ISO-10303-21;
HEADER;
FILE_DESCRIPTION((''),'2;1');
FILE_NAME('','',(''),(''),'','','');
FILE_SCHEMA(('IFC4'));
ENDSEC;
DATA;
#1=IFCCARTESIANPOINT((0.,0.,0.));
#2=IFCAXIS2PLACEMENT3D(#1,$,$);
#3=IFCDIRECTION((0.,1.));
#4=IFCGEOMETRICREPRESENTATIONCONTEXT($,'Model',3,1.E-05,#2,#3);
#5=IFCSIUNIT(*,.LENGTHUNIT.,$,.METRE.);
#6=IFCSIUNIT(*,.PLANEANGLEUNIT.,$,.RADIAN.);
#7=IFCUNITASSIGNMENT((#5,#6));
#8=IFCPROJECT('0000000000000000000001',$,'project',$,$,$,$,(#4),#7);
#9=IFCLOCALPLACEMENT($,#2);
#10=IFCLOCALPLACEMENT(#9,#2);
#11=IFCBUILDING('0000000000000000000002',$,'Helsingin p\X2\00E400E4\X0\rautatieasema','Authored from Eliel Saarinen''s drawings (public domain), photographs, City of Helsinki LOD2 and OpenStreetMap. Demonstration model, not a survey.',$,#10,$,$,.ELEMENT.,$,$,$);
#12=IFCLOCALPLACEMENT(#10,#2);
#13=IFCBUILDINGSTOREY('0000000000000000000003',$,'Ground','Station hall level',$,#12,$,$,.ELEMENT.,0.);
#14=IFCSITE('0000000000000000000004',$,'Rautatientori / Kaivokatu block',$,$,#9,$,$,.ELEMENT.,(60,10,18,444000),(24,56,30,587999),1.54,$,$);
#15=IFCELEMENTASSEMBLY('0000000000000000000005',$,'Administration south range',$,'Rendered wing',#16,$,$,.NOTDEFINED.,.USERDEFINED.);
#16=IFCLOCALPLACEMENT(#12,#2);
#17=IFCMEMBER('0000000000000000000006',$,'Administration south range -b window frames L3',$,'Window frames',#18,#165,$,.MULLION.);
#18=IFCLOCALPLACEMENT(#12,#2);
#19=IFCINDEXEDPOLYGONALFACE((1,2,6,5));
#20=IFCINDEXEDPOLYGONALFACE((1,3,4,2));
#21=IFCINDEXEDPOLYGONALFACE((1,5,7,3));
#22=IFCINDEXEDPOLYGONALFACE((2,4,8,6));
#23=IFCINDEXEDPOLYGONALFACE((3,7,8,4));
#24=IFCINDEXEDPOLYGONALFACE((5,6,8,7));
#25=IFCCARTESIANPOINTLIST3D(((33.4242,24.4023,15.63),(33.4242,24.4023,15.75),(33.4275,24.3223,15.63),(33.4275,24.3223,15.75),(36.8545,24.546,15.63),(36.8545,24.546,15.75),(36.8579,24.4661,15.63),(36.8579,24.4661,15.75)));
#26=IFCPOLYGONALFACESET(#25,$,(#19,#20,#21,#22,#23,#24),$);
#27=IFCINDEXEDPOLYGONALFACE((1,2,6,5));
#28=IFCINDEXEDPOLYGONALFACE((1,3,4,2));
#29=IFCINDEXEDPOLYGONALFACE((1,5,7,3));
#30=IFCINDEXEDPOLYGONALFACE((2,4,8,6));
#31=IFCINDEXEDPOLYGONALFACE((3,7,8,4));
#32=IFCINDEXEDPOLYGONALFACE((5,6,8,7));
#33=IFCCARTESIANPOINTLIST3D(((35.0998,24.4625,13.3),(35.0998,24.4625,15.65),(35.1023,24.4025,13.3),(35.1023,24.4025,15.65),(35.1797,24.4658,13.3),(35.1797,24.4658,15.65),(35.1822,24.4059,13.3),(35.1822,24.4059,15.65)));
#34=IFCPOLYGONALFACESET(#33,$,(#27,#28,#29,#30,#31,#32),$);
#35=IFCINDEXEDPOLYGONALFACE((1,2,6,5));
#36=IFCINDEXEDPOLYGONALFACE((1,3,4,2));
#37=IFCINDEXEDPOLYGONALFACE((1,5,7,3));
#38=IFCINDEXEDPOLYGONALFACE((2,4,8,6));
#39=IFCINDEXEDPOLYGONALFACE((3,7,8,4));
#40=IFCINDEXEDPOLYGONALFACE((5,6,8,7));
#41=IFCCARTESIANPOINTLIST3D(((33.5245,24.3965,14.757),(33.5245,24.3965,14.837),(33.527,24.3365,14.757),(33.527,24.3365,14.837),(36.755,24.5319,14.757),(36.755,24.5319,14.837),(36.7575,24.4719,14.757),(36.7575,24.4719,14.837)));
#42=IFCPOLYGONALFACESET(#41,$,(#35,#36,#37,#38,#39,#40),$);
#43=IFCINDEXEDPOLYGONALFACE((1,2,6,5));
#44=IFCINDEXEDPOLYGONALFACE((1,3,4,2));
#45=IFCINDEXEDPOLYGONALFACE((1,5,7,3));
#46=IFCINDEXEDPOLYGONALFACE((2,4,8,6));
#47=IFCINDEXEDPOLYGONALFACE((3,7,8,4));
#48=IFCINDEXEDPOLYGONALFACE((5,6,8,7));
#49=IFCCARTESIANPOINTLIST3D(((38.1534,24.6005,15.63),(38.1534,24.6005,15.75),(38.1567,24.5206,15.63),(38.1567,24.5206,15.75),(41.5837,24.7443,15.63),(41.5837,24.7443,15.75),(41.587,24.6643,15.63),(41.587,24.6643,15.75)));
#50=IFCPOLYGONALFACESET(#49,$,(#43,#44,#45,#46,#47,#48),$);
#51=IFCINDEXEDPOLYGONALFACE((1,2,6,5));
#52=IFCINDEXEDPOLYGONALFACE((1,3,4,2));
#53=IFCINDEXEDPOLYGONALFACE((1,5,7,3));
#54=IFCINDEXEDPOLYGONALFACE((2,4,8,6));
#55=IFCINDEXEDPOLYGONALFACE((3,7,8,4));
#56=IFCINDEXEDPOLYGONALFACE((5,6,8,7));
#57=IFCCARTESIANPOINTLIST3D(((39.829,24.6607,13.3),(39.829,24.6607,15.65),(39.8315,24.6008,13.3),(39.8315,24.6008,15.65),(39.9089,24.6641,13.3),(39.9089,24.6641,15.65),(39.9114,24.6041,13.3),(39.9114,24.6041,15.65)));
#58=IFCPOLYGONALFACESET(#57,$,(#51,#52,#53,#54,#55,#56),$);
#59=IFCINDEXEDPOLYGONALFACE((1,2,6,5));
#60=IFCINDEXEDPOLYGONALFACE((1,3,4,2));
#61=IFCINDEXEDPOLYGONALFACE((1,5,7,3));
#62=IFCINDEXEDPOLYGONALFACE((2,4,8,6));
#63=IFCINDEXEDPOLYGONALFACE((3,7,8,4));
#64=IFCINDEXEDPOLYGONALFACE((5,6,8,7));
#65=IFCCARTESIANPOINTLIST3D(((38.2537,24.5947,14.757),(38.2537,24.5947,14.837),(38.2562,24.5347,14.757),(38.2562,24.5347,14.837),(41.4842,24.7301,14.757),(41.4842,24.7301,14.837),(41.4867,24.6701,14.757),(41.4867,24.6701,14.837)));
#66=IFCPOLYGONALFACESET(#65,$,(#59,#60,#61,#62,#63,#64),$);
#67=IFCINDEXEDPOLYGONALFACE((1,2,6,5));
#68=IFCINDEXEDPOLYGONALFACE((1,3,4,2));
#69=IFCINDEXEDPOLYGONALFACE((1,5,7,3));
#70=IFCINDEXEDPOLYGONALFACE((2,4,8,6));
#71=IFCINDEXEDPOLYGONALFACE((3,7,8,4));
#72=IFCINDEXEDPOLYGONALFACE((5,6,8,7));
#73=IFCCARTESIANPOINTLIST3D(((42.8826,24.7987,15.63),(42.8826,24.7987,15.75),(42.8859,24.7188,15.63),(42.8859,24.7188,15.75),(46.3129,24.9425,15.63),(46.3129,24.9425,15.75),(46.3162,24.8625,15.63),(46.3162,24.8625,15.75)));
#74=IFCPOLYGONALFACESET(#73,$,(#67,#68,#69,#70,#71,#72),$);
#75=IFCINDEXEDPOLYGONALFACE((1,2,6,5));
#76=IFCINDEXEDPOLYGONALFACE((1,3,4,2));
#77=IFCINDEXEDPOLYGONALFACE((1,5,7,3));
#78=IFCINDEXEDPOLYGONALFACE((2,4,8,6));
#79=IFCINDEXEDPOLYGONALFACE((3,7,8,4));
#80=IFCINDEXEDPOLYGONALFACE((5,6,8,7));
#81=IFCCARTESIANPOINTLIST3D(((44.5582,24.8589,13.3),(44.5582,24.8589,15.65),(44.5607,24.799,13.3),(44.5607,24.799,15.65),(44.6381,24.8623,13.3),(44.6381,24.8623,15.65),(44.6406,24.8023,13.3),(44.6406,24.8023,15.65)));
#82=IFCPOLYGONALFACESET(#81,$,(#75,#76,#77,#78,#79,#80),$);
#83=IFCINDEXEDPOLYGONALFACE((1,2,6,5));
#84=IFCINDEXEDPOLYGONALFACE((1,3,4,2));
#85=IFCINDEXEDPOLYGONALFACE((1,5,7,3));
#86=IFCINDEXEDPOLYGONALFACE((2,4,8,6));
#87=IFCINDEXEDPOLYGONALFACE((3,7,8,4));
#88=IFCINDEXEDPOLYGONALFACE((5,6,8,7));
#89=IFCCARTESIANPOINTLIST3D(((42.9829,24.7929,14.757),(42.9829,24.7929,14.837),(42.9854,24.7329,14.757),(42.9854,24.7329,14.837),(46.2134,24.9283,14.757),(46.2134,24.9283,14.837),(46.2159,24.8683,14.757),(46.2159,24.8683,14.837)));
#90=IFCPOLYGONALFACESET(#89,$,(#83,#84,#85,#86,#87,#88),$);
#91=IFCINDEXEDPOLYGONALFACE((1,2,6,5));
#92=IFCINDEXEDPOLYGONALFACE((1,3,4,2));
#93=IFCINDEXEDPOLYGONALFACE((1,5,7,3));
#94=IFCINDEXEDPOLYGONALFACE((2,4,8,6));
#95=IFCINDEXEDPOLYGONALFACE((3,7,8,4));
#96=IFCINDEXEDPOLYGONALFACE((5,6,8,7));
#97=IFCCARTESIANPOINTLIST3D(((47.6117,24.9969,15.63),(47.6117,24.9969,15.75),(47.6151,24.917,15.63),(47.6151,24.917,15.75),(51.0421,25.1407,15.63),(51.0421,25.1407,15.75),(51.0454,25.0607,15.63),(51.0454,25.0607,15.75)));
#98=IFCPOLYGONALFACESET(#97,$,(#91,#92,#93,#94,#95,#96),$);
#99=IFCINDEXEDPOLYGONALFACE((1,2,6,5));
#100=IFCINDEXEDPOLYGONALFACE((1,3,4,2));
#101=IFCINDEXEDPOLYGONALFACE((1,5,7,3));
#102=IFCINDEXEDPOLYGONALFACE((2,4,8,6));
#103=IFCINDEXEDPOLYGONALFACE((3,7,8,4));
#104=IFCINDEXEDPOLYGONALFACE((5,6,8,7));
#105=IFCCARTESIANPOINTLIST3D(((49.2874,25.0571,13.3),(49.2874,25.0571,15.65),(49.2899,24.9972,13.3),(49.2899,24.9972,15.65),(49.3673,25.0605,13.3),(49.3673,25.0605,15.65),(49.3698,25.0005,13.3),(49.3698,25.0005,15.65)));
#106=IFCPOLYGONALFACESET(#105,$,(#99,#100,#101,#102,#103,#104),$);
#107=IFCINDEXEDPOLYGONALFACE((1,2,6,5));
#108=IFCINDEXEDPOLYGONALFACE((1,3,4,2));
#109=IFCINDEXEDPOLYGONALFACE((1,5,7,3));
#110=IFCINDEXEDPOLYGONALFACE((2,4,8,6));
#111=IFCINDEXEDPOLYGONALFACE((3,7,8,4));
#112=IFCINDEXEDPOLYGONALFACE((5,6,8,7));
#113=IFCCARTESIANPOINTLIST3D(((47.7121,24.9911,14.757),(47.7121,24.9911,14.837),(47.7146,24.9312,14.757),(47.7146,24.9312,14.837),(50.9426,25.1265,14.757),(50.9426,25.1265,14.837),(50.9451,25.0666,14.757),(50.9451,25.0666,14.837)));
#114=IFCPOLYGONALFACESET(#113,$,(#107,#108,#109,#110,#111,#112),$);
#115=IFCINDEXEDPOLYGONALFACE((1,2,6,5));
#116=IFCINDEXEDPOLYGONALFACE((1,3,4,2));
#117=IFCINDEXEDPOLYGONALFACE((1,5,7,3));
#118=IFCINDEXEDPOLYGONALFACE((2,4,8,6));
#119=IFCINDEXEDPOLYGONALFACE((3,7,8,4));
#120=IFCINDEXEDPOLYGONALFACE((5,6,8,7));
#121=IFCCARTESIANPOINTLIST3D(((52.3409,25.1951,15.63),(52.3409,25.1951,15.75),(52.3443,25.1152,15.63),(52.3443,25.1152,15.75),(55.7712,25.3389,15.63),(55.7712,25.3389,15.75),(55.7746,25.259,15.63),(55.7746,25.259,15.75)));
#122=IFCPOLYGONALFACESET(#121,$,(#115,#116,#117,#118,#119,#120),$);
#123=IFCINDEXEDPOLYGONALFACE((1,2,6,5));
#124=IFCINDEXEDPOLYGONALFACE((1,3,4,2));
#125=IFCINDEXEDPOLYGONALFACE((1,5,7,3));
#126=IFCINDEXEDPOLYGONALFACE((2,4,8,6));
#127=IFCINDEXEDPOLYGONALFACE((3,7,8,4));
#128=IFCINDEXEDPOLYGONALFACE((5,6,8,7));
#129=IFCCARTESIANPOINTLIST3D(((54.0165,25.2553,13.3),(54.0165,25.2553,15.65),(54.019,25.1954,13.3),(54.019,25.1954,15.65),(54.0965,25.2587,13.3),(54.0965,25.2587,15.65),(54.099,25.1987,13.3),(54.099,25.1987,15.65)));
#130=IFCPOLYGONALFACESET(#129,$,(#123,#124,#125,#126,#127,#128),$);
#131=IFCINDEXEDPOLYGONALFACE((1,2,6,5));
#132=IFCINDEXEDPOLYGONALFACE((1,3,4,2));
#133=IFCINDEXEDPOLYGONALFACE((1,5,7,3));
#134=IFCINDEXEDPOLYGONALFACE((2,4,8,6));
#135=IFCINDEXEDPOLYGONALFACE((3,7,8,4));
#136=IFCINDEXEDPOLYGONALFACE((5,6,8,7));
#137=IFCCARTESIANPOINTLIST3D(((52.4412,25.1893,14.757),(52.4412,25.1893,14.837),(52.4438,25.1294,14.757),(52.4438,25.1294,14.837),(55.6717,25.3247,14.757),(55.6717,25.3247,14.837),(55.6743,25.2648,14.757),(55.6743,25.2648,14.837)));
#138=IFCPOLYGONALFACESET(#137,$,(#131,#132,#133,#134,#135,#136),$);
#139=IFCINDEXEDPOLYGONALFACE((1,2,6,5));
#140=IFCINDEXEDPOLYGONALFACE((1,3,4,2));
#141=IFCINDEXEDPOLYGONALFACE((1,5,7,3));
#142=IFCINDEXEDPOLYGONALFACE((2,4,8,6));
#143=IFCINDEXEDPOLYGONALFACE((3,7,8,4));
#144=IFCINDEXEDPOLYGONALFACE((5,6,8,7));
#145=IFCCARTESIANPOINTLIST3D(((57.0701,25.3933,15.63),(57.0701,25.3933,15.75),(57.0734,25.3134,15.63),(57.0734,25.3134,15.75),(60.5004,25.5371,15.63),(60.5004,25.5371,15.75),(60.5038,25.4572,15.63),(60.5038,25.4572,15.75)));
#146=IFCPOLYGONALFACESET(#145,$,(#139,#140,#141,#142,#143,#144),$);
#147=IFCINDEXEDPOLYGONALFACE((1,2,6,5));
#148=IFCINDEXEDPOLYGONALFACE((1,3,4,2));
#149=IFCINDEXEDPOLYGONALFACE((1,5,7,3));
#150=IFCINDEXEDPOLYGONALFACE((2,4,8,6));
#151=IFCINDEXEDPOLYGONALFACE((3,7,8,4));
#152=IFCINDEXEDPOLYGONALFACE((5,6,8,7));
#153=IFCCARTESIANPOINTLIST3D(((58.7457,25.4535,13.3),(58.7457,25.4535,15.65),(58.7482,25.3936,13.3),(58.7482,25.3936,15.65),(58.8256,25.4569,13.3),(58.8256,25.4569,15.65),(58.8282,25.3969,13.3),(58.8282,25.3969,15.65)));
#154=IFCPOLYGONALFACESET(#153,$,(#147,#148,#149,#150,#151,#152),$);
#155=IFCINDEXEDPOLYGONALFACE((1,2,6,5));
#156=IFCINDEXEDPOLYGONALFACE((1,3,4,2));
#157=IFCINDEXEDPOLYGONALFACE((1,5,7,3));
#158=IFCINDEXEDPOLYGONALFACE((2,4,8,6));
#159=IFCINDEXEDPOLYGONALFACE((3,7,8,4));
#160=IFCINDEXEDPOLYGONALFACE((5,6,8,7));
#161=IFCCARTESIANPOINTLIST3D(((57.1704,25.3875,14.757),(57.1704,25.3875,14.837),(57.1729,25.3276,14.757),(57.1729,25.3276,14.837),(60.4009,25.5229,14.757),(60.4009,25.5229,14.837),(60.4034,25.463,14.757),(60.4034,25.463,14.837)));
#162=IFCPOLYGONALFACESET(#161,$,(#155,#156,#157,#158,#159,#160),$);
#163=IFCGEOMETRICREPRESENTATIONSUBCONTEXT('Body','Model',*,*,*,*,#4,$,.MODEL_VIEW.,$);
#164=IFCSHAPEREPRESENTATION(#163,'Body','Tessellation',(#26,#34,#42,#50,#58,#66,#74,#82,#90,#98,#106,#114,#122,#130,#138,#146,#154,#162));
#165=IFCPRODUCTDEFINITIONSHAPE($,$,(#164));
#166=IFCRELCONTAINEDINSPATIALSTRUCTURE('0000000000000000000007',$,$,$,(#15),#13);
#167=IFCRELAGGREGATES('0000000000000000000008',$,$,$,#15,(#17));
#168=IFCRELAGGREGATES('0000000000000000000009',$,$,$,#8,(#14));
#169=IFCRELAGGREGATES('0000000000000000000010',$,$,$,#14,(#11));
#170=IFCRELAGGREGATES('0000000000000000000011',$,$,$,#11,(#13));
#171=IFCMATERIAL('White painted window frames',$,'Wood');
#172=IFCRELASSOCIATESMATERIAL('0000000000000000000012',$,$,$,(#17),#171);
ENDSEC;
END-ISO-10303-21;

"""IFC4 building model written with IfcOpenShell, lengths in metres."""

from ifc_helpers import new_model, si_unit, direction, frame, frame_2d, origin, place, context, subcontext, project, spatial, rectangle, extrude, material, element, aggregate, save


model = new_model("IFC4")

# Units and contexts
model_context = context("Model", 3, precision=1e-05, world=origin(), true_north=direction((0.0, 1.0)))
body_context = subcontext(model_context, "Body", "Model", "MODEL_VIEW")
ifc_project = project(units=[si_unit("LENGTHUNIT", "METRE"), si_unit("PLANEANGLEUNIT", "RADIAN")], contexts=[model_context])

# Site, building, storey
site_placement = place(None, origin())
site = spatial("IfcSite", under=ifc_project, at=site_placement, Name="Rautatientori / Kaivokatu block", CompositionType="ELEMENT", RefLatitude=(60, 10, 18, 444000), RefLongitude=(24, 56, 30, 587999), RefElevation=1.54)
building_placement = place(site_placement, origin())
building = spatial("IfcBuilding", under=site, at=building_placement, Name="Helsingin päärautatieasema", Description="Authored from Eliel Saarinen's drawings (public domain), photographs, City of Helsinki LOD2 and OpenStreetMap. Demonstration model, not a survey.", CompositionType="ELEMENT")
storey_placement = place(building_placement, origin())
storey = spatial("IfcBuildingStorey", under=building, at=storey_placement, Name="Ground", Description="Station hall level", CompositionType="ELEMENT", Elevation=0.0)

# Element assembly, member
assembly_1_placement = place(building_placement, origin())
assembly_1 = element("IfcElementAssembly", 1, at=assembly_1_placement, inside=storey, Name="Administration south range", ObjectType="Rendered wing", AssemblyPlace="NOTDEFINED", PredefinedType="USERDEFINED")
ifc_material_1 = material(Name="White painted window frames", Category="Wood")
member_1_placement = place(building_placement, origin())
member_1 = element("IfcMember", 2, at=member_1_placement, material=ifc_material_1, Name="Administration south range -b window frames L3", ObjectType="Window frames", PredefinedType="MULLION", context=body_context, shape_type="SweptSolid", body=[
    extrude(rectangle(XDim=3.4333, YDim=0.08, at=frame_2d((0.0, 0.0), x_axis=(0.999123, 0.041876))), frame((35.141, 24.4342, 15.63)), (0.0, 0.0, 1.0), 0.12),
    extrude(rectangle(XDim=0.08, YDim=0.06, at=frame_2d((0.0, 0.0), x_axis=(0.999123, 0.041876))), frame((35.141, 24.4342, 13.3)), (0.0, 0.0, 1.0), 2.35),
    extrude(rectangle(XDim=3.2333, YDim=0.06, at=frame_2d((0.0, 0.0), x_axis=(0.999123, 0.041876))), frame((35.141, 24.4342, 14.757)), (0.0, 0.0, 1.0), 0.08),
    extrude(rectangle(XDim=3.4333, YDim=0.08, at=frame_2d((0.0, 0.0), x_axis=(0.999123, 0.041876))), frame((39.8702, 24.6324, 15.63)), (0.0, 0.0, 1.0), 0.12),
    extrude(rectangle(XDim=0.08, YDim=0.06, at=frame_2d((0.0, 0.0), x_axis=(0.999123, 0.041876))), frame((39.8702, 24.6324, 13.3)), (0.0, 0.0, 1.0), 2.35),
    extrude(rectangle(XDim=3.2333, YDim=0.06, at=frame_2d((0.0, 0.0), x_axis=(0.999123, 0.041876))), frame((39.8702, 24.6324, 14.757)), (0.0, 0.0, 1.0), 0.08),
    extrude(rectangle(XDim=3.4333, YDim=0.08, at=frame_2d((0.0, 0.0), x_axis=(0.999123, 0.041876))), frame((44.5994, 24.8306, 15.63)), (0.0, 0.0, 1.0), 0.12),
    extrude(rectangle(XDim=0.08, YDim=0.06, at=frame_2d((0.0, 0.0), x_axis=(0.999123, 0.041876))), frame((44.5994, 24.8306, 13.3)), (0.0, 0.0, 1.0), 2.35),
    extrude(rectangle(XDim=3.2333, YDim=0.06, at=frame_2d((0.0, 0.0), x_axis=(0.999123, 0.041876))), frame((44.5994, 24.8306, 14.757)), (0.0, 0.0, 1.0), 0.08),
    extrude(rectangle(XDim=3.4333, YDim=0.08, at=frame_2d((0.0, 0.0), x_axis=(0.999123, 0.041876))), frame((49.3286, 25.0288, 15.63)), (0.0, 0.0, 1.0), 0.12),
    extrude(rectangle(XDim=0.08, YDim=0.06, at=frame_2d((0.0, 0.0), x_axis=(0.999123, 0.041876))), frame((49.3286, 25.0288, 13.3)), (0.0, 0.0, 1.0), 2.35),
    extrude(rectangle(XDim=3.2333, YDim=0.06, at=frame_2d((0.0, 0.0), x_axis=(0.999123, 0.041876))), frame((49.3286, 25.0288, 14.757)), (0.0, 0.0, 1.0), 0.08),
    extrude(rectangle(XDim=3.4333, YDim=0.08, at=frame_2d((0.0, 0.0), x_axis=(0.999123, 0.041876))), frame((54.0578, 25.227, 15.63)), (0.0, 0.0, 1.0), 0.12),
    extrude(rectangle(XDim=0.08, YDim=0.06, at=frame_2d((0.0, 0.0), x_axis=(0.999123, 0.041876))), frame((54.0578, 25.227, 13.3)), (0.0, 0.0, 1.0), 2.35),
    extrude(rectangle(XDim=3.2333, YDim=0.06, at=frame_2d((0.0, 0.0), x_axis=(0.999123, 0.041876))), frame((54.0578, 25.227, 14.757)), (0.0, 0.0, 1.0), 0.08),
    extrude(rectangle(XDim=3.4333, YDim=0.08, at=frame_2d((0.0, 0.0), x_axis=(0.999123, 0.041876))), frame((58.7869, 25.4252, 15.63)), (0.0, 0.0, 1.0), 0.12),
    extrude(rectangle(XDim=0.08, YDim=0.06, at=frame_2d((0.0, 0.0), x_axis=(0.999123, 0.041876))), frame((58.7869, 25.4252, 13.3)), (0.0, 0.0, 1.0), 2.35),
    extrude(rectangle(XDim=3.2333, YDim=0.06, at=frame_2d((0.0, 0.0), x_axis=(0.999123, 0.041876))), frame((58.7869, 25.4252, 14.757)), (0.0, 0.0, 1.0), 0.08),
])

aggregate(assembly_1, [member_1])

save(model, "model.ifc")
